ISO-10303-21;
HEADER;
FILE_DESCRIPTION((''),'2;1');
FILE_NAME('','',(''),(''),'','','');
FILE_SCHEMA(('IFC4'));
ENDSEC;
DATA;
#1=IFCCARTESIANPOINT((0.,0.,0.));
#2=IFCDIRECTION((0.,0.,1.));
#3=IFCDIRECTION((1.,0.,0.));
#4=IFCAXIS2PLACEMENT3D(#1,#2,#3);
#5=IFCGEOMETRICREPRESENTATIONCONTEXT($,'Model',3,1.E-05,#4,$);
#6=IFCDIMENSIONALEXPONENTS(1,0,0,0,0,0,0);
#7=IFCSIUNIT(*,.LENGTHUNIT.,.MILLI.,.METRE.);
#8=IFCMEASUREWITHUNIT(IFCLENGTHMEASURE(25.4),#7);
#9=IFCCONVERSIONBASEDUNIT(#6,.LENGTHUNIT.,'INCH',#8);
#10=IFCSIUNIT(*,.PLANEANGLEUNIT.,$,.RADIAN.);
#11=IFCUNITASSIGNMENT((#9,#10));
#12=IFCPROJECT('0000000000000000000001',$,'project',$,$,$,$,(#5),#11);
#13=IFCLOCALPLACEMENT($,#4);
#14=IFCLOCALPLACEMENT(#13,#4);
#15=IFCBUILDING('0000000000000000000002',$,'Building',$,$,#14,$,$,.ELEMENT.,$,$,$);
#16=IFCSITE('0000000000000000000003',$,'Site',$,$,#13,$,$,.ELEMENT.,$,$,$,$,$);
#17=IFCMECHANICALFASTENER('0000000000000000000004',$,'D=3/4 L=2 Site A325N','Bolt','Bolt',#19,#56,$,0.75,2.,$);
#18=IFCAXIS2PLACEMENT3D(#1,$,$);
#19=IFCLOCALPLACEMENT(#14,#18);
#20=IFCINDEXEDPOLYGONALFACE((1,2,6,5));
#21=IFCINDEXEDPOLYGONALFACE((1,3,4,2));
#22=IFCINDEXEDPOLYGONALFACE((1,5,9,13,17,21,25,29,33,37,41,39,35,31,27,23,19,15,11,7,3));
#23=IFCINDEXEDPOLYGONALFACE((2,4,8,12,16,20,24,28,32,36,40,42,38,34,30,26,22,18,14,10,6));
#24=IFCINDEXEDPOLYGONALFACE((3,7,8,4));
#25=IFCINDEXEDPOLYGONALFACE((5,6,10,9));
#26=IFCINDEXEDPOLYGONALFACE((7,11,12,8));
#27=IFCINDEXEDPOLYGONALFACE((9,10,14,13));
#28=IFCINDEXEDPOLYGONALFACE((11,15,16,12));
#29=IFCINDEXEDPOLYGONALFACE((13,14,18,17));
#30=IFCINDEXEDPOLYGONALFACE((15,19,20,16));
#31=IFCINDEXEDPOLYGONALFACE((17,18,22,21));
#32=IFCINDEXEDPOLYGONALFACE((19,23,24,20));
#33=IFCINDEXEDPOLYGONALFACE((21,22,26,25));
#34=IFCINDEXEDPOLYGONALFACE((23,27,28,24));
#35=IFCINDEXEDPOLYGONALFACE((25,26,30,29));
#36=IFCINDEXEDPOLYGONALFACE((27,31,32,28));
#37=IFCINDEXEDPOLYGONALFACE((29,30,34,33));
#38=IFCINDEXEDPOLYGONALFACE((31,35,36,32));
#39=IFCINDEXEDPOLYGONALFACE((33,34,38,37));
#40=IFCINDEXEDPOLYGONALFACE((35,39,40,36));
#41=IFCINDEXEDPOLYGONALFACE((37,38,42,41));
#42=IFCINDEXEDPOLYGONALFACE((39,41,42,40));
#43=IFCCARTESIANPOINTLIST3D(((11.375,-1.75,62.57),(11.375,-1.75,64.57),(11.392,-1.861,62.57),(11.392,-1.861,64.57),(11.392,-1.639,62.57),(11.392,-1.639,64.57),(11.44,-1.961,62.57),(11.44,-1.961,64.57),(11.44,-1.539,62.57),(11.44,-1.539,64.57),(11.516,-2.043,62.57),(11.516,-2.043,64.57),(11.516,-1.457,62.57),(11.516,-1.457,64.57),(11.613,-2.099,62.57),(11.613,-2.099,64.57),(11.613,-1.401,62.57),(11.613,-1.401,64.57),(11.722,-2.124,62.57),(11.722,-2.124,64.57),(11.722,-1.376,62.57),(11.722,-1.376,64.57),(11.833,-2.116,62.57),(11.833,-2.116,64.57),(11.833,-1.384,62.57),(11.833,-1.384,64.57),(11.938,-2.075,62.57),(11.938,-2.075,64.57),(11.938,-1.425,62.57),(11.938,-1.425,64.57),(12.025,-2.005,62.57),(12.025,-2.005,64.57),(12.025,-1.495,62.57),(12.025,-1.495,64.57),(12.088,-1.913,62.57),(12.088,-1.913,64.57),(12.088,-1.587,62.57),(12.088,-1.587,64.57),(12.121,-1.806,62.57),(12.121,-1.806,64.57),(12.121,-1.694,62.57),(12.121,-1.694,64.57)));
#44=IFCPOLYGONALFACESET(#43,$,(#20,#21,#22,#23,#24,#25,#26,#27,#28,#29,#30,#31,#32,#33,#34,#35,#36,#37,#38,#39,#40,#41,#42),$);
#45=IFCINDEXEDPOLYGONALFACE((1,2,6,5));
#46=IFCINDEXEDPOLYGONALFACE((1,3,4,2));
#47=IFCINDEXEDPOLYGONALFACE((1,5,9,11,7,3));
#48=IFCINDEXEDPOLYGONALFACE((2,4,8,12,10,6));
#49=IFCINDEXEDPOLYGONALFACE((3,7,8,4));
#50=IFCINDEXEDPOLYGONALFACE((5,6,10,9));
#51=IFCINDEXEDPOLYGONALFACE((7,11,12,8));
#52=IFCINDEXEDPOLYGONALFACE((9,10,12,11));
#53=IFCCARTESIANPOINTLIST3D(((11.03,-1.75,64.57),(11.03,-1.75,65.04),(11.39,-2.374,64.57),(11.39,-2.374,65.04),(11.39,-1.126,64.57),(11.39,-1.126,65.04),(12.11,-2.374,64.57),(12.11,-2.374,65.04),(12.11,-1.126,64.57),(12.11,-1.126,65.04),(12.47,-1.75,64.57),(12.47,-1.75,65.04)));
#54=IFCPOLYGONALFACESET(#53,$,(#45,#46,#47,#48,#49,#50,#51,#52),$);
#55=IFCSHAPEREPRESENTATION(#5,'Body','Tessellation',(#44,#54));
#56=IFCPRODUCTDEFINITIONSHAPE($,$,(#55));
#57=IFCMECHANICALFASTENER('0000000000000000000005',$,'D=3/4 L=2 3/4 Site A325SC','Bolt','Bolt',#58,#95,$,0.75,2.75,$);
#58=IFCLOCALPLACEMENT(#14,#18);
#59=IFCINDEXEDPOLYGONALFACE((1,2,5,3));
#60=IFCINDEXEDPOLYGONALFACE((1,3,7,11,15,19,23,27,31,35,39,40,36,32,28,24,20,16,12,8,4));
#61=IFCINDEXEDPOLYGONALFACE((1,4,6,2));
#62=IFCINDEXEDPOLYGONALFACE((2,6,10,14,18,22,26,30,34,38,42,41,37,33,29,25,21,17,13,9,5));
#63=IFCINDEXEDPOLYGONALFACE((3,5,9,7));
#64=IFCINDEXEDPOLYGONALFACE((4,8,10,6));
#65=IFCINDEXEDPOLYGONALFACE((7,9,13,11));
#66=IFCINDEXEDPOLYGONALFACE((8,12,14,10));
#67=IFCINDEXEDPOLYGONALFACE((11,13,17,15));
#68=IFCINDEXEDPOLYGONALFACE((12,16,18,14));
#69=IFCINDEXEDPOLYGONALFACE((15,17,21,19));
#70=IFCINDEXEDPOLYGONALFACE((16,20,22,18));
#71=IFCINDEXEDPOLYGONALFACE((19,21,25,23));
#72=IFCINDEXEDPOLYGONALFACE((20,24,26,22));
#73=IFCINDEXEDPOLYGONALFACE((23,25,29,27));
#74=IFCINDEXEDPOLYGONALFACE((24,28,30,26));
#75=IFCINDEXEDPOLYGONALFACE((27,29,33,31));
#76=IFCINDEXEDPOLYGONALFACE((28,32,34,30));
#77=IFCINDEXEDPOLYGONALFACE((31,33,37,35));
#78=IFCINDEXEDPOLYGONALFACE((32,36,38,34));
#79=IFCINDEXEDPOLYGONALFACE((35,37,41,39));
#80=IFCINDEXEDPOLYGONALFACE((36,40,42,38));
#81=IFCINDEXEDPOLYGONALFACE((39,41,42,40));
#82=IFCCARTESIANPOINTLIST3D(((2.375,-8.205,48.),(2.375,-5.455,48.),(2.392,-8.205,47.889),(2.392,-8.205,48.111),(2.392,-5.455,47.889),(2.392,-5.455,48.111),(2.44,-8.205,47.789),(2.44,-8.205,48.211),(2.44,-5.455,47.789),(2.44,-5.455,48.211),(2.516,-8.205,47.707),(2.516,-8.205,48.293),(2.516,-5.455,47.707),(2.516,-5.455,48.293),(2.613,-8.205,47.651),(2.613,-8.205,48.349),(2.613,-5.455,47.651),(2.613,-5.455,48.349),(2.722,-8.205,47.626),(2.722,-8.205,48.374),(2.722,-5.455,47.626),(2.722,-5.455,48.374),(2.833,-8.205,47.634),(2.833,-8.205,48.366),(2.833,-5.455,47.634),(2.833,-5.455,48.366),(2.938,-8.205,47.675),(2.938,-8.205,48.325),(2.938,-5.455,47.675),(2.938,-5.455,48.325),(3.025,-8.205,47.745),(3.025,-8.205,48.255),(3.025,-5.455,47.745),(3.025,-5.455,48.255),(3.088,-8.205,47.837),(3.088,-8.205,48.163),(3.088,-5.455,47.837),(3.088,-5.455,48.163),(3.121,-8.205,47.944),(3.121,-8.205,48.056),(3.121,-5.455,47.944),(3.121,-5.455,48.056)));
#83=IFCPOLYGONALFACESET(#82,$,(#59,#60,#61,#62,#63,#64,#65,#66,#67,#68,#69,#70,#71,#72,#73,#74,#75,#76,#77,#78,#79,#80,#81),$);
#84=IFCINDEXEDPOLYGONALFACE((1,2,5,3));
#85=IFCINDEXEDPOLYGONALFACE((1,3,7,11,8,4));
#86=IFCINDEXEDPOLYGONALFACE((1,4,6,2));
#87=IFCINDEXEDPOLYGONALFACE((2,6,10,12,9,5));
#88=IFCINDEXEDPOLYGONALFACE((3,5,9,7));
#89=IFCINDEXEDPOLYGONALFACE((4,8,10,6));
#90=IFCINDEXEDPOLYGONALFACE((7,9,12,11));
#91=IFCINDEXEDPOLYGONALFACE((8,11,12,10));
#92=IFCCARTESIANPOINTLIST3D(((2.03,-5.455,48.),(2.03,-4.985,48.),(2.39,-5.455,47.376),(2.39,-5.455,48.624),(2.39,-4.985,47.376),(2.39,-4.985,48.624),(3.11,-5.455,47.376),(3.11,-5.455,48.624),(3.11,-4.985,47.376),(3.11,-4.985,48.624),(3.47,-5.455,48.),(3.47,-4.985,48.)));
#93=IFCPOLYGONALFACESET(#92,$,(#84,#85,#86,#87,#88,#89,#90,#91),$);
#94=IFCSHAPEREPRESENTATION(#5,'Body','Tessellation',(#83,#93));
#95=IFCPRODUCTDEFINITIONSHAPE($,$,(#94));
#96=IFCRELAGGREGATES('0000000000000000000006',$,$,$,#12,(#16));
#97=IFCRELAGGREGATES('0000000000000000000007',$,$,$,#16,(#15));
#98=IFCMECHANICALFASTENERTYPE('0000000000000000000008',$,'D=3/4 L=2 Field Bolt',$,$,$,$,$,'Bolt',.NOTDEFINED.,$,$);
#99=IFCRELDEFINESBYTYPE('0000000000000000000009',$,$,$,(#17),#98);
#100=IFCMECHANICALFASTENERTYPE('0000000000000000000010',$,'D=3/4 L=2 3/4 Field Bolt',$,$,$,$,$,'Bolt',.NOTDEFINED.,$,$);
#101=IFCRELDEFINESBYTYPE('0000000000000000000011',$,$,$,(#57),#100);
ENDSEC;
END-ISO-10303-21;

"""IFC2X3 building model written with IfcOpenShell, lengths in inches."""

from ifc_helpers import new_model, entity, si_unit, converted_unit, frame, origin_with_axes, origin_2d_with_axis, place, context, project, spatial, polyline, circle, outline, extrude, source, transform, mapped, type_object, type_shapes, element, save


model = new_model("IFC2X3")

# Units and contexts
model_context = context("Model", 3, precision=1e-05, world=origin_with_axes())
ifc_project = project(units=[converted_unit("LENGTHUNIT", "INCH", entity("IfcLengthMeasure", 25.4), si_unit("LENGTHUNIT", "METRE", prefix="MILLI"), dimensions=[1, 0, 0, 0, 0, 0, 0]), si_unit("PLANEANGLEUNIT", "RADIAN")], contexts=[model_context])

# Site, building
site_placement = place(None, origin_with_axes())
site = spatial("IfcSite", under=ifc_project, at=site_placement, Name="Site", CompositionType="ELEMENT")
building_placement = place(site_placement, origin_with_axes())
building = spatial("IfcBuilding", under=site, at=building_placement, Name="Building", CompositionType="ELEMENT")

# Shared definitions
assembly_1_placement = place(building_placement, frame((14.0, 0.0, 49.0), z_axis=(0.0, -1.0, 0.0), x_axis=(0.0, 0.0, 1.0)))

# Mechanical fasteners
mechanical_fastener_type_1 = type_object("IfcMechanicalFastenerType", Name="D=3/4 L=2 Field Bolt", ElementType="Bolt")
shared_shape_1 = source(origin_with_axes(), model_context, "Body", "SweptSolid", [
    extrude(circle(Radius=0.375, at=origin_2d_with_axis()), frame((0.0, 0.0, 0.0), z_axis=(1.0, 0.0, 0.0), x_axis=(0.0, 1.0, 0.0)), (0.0, 0.0, 1.0), 2.0),
    extrude(outline(polyline([(-0.72, 0.0), (-0.36, 0.624), (0.36, 0.624), (0.72, 0.0), (0.36, -0.624), (-0.36, -0.624), (-0.72, 0.0)])), frame((0.0, 0.0, 0.0), z_axis=(1.0, 0.0, 0.0), x_axis=(0.0, 1.0, 0.0)), (0.0, 0.0, -1.0), 0.47),
])
type_shapes(mechanical_fastener_type_1, [shared_shape_1])
placement_1 = place(assembly_1_placement, frame((15.57, 2.25, -1.75), z_axis=(0.0, 0.0, -1.0), x_axis=(-1.0, 0.0, 0.0)))
mechanical_fastener_1_placement = place(placement_1, frame((0.0, 0.0, -3.5), z_axis=(0.0, 0.0, 1.0), x_axis=(1.0, 0.0, 0.0)))
element("IfcMechanicalFastener", 1, at=mechanical_fastener_1_placement, type_object=mechanical_fastener_type_1, Name="D=3/4 L=2 Site A325N", Description="Bolt", ObjectType="Bolt", NominalDiameter=0.75, NominalLength=2.0, context=model_context, shape_type="MappedRepresentation", body=[
    mapped(shared_shape_1, transform((0.0, 0.0, 0.0), scale=1.0)),
])
mechanical_fastener_type_2 = type_object("IfcMechanicalFastenerType", Name="D=3/4 L=2 3/4 Field Bolt", ElementType="Bolt")
shared_shape_2 = source(origin_with_axes(), model_context, "Body", "SweptSolid", [
    extrude(circle(Radius=0.375, at=origin_2d_with_axis()), frame((0.0, 0.0, 0.0), z_axis=(1.0, 0.0, 0.0), x_axis=(0.0, 1.0, 0.0)), (0.0, 0.0, 1.0), 2.75),
    extrude(outline(polyline([(-0.72, 0.0), (-0.36, 0.624), (0.36, 0.624), (0.72, 0.0), (0.36, -0.624), (-0.36, -0.624), (-0.72, 0.0)])), frame((0.0, 0.0, 0.0), z_axis=(1.0, 0.0, 0.0), x_axis=(0.0, 1.0, 0.0)), (0.0, 0.0, -1.0), 0.47),
])
type_shapes(mechanical_fastener_type_2, [shared_shape_2])
placement_2 = place(building_placement, frame((0.0, 0.0, 46.0), z_axis=(0.0, 0.0, 1.0), x_axis=(0.0, -1.0, 0.0)))
placement_3 = place(placement_2, frame((5.455, -2.75, 2.0), z_axis=(0.0, 0.0, -1.0), x_axis=(1.0, 0.0, 0.0)))
mechanical_fastener_2_placement = place(placement_3, frame((0.0, -5.5, 0.0), z_axis=(0.0, 0.0, 1.0), x_axis=(1.0, 0.0, 0.0)))
element("IfcMechanicalFastener", 2, at=mechanical_fastener_2_placement, type_object=mechanical_fastener_type_2, Name="D=3/4 L=2 3/4 Site A325SC", Description="Bolt", ObjectType="Bolt", NominalDiameter=0.75, NominalLength=2.75, context=model_context, shape_type="MappedRepresentation", body=[
    mapped(shared_shape_2, transform((0.0, 0.0, 0.0), scale=1.0)),
])

save(model, "model.ifc")
